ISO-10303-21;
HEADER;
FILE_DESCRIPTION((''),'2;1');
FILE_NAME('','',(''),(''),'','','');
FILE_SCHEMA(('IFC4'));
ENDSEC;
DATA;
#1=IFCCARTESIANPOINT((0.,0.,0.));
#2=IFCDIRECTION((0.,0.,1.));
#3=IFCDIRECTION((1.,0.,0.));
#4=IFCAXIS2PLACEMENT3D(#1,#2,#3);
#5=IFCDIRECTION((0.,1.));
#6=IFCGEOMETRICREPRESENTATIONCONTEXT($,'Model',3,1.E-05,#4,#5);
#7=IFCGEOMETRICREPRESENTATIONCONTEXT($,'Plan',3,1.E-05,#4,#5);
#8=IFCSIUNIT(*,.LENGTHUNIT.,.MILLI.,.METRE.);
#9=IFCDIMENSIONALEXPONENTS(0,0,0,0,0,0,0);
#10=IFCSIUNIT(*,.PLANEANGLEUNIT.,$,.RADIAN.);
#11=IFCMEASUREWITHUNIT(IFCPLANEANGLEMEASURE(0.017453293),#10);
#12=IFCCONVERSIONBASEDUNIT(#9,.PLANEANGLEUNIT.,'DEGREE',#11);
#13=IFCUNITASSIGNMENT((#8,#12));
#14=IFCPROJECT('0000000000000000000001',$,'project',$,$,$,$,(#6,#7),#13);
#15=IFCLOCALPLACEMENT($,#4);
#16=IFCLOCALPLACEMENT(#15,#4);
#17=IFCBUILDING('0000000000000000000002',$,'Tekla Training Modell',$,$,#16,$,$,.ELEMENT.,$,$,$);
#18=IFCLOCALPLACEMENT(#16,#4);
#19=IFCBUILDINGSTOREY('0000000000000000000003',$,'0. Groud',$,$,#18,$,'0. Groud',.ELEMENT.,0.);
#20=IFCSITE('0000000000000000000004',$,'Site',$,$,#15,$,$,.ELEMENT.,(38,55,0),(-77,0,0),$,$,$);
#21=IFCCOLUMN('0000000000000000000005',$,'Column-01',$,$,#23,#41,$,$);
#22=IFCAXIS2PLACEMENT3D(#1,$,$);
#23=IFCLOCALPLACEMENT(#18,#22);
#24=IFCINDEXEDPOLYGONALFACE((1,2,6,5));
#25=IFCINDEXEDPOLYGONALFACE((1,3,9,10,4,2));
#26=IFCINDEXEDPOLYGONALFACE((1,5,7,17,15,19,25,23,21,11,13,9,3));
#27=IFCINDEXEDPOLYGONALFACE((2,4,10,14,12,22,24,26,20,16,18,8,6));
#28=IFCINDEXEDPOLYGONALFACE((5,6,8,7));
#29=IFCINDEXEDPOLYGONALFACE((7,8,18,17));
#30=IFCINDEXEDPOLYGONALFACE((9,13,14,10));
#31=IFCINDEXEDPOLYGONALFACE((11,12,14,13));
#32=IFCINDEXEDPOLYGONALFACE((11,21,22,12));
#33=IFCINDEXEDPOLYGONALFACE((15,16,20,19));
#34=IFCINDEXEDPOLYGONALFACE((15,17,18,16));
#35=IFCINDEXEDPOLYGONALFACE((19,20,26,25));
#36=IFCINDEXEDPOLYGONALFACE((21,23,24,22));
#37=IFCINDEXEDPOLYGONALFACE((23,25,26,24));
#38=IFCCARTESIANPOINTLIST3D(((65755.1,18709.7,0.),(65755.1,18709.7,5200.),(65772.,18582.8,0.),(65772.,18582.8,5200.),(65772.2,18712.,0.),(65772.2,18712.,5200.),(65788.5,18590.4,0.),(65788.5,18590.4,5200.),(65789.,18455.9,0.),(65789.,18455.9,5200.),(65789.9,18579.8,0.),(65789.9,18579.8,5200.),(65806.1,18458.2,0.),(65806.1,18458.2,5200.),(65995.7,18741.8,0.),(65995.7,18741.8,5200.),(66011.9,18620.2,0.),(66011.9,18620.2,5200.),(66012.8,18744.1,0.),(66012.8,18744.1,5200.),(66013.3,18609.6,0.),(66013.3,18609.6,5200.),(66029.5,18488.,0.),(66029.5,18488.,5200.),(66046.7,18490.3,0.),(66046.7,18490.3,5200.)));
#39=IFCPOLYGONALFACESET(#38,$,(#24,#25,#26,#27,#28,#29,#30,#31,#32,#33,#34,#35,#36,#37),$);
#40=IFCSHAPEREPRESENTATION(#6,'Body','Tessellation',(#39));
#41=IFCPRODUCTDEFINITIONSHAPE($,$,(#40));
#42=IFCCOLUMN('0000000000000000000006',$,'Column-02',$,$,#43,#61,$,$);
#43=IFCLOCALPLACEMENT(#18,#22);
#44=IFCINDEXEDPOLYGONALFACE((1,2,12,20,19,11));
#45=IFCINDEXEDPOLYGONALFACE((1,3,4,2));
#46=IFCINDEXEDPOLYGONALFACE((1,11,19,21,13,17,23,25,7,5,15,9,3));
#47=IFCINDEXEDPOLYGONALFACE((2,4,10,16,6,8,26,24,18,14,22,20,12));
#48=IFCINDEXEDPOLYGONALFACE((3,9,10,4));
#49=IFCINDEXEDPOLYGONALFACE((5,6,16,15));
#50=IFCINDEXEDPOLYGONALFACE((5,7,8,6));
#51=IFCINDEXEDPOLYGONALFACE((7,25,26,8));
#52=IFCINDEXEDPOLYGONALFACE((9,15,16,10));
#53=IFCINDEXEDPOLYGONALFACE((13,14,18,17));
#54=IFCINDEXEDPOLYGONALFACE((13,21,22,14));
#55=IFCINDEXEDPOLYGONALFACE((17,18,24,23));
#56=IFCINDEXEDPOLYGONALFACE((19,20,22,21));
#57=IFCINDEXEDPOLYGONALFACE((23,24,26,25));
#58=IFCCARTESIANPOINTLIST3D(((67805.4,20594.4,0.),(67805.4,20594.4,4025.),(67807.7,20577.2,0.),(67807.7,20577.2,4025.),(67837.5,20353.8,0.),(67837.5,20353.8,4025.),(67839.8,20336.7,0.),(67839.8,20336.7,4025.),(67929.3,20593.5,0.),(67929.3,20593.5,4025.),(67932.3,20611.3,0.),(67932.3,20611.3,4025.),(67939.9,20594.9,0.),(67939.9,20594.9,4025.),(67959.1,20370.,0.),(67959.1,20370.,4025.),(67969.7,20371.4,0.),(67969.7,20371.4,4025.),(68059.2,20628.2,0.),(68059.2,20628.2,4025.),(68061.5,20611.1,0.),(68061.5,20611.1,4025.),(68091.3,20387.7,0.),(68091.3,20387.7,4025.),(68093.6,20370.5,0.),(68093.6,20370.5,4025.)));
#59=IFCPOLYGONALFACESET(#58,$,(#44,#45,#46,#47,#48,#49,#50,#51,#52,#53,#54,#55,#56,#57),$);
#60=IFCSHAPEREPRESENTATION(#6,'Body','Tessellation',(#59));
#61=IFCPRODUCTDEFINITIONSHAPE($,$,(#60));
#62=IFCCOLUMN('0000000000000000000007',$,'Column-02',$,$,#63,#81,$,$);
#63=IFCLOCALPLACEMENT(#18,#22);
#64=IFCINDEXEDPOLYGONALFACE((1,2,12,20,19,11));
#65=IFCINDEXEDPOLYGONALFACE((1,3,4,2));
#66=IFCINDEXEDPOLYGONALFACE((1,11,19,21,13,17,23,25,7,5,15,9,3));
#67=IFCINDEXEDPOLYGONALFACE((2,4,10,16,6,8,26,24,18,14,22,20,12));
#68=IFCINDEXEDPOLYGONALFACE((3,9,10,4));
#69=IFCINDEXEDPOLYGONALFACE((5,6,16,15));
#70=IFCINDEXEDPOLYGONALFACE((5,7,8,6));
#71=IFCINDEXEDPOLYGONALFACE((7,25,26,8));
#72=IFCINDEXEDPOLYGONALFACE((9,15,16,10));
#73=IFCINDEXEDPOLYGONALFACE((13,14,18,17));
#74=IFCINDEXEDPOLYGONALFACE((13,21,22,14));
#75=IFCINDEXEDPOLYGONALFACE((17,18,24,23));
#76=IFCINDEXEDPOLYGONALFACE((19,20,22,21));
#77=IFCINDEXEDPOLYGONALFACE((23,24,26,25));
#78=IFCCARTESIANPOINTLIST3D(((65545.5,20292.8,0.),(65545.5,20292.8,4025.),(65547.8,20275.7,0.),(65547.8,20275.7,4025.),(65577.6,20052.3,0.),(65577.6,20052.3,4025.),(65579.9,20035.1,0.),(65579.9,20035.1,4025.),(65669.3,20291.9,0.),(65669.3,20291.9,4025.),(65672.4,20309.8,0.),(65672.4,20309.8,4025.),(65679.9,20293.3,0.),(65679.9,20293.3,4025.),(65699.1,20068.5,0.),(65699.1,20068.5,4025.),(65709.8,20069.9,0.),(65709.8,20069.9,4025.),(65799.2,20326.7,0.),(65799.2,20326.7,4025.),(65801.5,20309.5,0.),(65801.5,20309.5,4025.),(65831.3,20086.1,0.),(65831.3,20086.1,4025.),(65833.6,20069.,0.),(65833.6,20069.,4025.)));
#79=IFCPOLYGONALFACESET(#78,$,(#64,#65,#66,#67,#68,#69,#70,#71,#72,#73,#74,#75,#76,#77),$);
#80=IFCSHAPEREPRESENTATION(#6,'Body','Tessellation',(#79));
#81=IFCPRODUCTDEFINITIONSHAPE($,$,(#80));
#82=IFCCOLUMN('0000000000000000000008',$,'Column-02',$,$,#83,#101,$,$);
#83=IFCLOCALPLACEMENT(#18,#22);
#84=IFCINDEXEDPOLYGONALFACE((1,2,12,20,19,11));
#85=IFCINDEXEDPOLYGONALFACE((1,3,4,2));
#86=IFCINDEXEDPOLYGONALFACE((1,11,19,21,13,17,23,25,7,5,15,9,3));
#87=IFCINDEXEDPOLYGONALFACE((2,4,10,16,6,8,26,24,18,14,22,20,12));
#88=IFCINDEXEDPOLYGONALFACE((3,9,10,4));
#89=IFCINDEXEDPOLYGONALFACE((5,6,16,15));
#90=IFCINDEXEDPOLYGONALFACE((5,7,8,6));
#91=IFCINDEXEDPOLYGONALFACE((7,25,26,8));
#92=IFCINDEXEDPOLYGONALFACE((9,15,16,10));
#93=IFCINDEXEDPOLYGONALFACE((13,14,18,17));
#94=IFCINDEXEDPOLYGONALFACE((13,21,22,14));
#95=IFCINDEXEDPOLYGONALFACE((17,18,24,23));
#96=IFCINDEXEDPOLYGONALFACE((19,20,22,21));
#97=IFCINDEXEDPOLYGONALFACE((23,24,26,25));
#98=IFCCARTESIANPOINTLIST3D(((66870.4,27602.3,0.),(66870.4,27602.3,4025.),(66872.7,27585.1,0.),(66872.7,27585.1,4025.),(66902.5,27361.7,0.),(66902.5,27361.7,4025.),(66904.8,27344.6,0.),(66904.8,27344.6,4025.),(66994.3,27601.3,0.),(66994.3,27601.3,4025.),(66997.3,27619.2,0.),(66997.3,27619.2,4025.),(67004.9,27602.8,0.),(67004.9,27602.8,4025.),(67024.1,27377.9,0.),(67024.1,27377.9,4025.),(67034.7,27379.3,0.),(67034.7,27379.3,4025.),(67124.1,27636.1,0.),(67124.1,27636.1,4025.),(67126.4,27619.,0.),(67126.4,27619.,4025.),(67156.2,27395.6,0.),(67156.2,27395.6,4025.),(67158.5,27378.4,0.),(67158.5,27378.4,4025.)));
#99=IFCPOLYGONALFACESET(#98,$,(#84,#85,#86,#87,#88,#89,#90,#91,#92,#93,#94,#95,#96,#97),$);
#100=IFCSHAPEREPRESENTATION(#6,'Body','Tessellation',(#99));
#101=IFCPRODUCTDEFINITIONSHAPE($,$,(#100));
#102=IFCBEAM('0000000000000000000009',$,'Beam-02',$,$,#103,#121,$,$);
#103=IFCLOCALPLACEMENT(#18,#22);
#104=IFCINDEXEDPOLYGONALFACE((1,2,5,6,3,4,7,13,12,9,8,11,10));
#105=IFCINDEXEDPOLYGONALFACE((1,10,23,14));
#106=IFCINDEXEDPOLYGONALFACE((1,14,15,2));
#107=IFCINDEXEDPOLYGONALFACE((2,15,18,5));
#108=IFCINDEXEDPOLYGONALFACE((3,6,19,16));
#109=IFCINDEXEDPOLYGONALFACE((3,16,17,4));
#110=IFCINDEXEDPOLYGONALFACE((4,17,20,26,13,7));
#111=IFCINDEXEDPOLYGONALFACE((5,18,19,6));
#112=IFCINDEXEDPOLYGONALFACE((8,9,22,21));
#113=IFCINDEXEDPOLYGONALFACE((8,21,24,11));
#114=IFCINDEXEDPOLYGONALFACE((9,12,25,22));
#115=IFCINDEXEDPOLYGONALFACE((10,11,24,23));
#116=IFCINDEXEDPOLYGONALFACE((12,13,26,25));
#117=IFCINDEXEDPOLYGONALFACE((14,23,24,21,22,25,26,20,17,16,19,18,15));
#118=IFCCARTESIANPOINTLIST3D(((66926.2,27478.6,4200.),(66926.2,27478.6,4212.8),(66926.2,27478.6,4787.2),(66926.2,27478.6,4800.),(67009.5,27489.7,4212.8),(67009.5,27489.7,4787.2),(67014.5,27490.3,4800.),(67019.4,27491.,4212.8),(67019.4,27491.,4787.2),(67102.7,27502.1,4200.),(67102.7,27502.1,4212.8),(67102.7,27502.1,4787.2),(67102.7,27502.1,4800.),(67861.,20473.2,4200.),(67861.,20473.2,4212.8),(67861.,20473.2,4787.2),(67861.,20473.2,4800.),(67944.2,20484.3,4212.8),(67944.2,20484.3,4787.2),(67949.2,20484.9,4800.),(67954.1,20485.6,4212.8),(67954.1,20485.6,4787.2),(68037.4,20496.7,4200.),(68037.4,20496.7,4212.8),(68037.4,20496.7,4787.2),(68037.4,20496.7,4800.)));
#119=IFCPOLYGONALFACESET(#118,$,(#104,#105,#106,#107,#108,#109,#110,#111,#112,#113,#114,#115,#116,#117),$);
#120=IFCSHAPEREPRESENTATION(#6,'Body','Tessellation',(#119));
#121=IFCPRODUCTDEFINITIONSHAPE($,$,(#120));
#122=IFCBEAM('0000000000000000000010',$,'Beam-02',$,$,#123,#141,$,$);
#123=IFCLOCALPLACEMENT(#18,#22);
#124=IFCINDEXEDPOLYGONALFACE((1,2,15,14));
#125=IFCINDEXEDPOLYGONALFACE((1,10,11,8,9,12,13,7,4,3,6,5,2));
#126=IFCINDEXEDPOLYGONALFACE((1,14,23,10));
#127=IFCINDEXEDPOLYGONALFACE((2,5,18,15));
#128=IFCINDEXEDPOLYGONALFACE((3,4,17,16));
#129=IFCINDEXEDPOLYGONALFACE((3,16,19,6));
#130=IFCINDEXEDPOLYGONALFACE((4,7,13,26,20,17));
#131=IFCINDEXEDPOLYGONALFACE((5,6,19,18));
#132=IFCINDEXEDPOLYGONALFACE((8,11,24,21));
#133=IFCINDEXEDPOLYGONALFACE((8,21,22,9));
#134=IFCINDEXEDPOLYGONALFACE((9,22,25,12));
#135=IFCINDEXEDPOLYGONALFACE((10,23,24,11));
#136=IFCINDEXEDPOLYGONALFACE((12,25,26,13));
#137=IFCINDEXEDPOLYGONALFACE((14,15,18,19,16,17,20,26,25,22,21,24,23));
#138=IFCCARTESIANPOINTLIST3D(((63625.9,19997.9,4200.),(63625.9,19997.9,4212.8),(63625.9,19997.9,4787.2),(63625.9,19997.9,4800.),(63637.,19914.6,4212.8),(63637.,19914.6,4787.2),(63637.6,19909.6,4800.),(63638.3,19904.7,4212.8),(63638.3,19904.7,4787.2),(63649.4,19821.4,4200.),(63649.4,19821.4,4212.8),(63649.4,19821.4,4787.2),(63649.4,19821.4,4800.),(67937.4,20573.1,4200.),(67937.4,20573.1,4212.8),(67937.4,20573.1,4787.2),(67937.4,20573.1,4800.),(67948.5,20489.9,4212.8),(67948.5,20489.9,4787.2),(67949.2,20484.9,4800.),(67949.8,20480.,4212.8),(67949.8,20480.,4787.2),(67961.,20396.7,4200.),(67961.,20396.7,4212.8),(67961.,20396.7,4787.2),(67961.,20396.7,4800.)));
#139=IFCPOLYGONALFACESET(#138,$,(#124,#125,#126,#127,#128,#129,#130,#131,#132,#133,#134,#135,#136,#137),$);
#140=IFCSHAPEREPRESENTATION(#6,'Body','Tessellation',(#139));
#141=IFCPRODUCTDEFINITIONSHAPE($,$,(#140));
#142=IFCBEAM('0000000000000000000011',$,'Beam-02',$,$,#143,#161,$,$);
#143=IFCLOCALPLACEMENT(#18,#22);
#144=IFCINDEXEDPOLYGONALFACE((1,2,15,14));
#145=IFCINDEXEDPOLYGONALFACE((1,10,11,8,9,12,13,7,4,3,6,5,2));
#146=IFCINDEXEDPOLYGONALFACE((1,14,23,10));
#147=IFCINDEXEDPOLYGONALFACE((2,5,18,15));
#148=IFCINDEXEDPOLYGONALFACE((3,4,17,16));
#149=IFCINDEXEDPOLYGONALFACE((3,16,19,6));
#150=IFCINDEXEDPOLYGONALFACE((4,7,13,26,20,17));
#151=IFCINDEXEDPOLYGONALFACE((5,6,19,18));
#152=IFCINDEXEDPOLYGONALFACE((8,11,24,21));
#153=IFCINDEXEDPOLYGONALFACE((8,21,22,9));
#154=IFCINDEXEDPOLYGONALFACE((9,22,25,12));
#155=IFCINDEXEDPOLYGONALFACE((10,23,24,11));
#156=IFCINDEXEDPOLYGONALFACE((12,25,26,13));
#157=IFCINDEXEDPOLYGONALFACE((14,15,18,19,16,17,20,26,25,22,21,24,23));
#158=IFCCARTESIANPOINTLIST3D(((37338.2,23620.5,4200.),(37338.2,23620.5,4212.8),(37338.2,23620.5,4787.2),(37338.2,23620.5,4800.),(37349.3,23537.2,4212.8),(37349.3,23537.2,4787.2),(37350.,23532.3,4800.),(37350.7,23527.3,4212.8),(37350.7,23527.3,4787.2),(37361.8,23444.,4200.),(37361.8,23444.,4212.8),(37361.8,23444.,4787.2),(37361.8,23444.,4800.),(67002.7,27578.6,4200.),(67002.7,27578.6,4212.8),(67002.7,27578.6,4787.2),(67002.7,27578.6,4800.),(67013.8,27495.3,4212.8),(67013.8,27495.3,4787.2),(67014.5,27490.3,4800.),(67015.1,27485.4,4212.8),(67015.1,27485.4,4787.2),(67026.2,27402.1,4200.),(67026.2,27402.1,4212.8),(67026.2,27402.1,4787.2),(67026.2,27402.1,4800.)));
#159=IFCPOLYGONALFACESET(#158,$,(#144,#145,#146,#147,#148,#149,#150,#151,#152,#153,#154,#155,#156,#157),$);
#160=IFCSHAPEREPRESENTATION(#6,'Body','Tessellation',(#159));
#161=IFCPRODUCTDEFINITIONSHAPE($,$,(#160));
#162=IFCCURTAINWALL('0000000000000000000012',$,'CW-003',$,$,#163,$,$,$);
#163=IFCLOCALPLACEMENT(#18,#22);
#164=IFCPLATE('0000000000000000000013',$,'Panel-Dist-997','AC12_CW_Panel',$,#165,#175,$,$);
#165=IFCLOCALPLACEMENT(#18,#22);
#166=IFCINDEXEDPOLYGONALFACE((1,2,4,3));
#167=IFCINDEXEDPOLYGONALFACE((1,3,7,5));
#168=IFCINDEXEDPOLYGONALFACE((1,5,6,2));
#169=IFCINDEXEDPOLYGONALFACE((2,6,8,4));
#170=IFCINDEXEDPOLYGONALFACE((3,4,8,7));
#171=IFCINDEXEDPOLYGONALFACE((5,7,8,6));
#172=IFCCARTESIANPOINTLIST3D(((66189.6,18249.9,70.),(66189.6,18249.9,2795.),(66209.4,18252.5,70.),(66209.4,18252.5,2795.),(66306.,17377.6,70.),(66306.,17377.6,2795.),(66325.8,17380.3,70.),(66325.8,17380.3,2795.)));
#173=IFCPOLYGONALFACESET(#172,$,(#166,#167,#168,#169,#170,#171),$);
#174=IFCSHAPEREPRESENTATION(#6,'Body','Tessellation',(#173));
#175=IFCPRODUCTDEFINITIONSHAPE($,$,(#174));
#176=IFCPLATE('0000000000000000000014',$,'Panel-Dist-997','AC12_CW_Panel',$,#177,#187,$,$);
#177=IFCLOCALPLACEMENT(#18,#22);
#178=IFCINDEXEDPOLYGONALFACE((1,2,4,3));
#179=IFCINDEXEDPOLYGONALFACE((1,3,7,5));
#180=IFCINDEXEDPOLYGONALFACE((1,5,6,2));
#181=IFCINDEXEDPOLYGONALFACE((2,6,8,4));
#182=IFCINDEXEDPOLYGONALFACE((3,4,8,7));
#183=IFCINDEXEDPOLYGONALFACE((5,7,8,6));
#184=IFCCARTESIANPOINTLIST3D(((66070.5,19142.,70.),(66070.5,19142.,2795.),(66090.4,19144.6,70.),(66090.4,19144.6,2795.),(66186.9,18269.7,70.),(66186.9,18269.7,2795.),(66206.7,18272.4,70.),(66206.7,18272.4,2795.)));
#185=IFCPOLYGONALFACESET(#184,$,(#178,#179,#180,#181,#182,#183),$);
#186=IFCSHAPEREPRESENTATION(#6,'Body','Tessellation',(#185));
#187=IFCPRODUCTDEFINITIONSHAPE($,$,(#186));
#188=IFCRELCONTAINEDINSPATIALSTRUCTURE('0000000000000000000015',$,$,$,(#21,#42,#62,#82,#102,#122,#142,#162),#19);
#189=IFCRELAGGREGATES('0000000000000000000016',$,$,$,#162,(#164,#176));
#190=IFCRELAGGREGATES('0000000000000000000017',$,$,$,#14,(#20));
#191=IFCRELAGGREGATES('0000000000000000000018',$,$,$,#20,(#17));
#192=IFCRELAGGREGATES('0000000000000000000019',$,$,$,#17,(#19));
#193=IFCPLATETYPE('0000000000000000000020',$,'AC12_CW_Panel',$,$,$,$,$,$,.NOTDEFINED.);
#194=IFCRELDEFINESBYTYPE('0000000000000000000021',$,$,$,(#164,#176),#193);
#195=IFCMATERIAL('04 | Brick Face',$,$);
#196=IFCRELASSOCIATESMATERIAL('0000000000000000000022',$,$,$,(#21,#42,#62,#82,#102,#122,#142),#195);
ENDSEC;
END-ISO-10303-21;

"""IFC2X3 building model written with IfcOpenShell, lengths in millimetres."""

from ifc_helpers import new_model, entity, si_unit, converted_unit, direction, frame, origin_with_axes, place, context, project, spatial, polyline, outline, extrude, source, transform, mapped, material, type_object, element, aggregate, save


model = new_model("IFC2X3")

# Units and contexts
model_context = context("Model", 3, precision=1e-05, world=origin_with_axes(), true_north=direction((0.0, 1.0)))
plan_context = context("Plan", 3, precision=1e-05, world=origin_with_axes(), true_north=direction((0.0, 1.0)))
ifc_project = project(units=[si_unit("LENGTHUNIT", "METRE", prefix="MILLI"), converted_unit("PLANEANGLEUNIT", "DEGREE", entity("IfcPlaneAngleMeasure", 0.017453293), si_unit("PLANEANGLEUNIT", "RADIAN"), dimensions=[0, 0, 0, 0, 0, 0, 0])], contexts=[model_context, plan_context])

# Site, building, storey
site_placement = place(None, origin_with_axes())
site = spatial("IfcSite", under=ifc_project, at=site_placement, Name="Site", CompositionType="ELEMENT", RefLatitude=(38, 55, 0), RefLongitude=(-77, 0, 0))
building_placement = place(site_placement, origin_with_axes())
building = spatial("IfcBuilding", under=site, at=building_placement, Name="Tekla Training Modell", CompositionType="ELEMENT")
storey_placement = place(building_placement, origin_with_axes())
storey = spatial("IfcBuildingStorey", under=building, at=storey_placement, Name="0. Groud", LongName="0. Groud", CompositionType="ELEMENT", Elevation=0.0)

# Columns
ifc_material_1 = material(Name="04 | Brick Face")
column_placement = place(storey_placement, frame((65900.9, 18600.0, 0.0), z_axis=(0.0, 0.0, 1.0), x_axis=(-0.132256, 0.991216, 0.0)))
element("IfcColumn", 1, at=column_placement, inside=storey, material=ifc_material_1, Name="Column-01", context=model_context, shape_type="SweptSolid", body=[
    extrude(outline(polyline([(0.0, 130.0), (-128.0, 130.0), (-128.0, 112.7), (-5.3, 112.7), (-5.3, -112.7), (-128.0, -112.7), (-128.0, -130.0), (128.0, -130.0), (128.0, -112.7), (5.3, -112.7), (5.3, 112.7), (128.0, 112.7), (128.0, 130.0), (0.0, 130.0)])), origin_with_axes(), (0.0, 0.0, 1.0), 5200.0),
])
for number, where, z_axis, x_axis, name in (
    (2, (67949.5, 20482.5, 0.0), (0.0, 0.0, 1.0), (0.991216, 0.132256, 0.0), "Column-02"),
    (3, (65689.5, 20180.9, 0.0), (0.0, 0.0, 1.0), (0.991216, 0.132256, 0.0), "Column-02"),
    (4, (67014.5, 27490.3, 0.0), (0.0, 0.0, 1.0), (0.991216, 0.132256, 0.0), "Column-02"),
):
    element("IfcColumn", number, at=place(storey_placement, frame(where, z_axis=z_axis, x_axis=x_axis)), inside=storey, material=ifc_material_1, Name=name, context=model_context, shape_type="SweptSolid", body=[
        extrude(outline(polyline([(0.0, 130.0), (-128.0, 130.0), (-128.0, 112.7), (-5.3, 112.7), (-5.3, -112.7), (-128.0, -112.7), (-128.0, -130.0), (128.0, -130.0), (128.0, -112.7), (5.3, -112.7), (5.3, 112.7), (128.0, 112.7), (128.0, 130.0), (0.0, 130.0)])), origin_with_axes(), (0.0, 0.0, 1.0), 4025.0),
    ])

# Beams
beam_1_placement = place(storey_placement, frame((67949.2, 20484.9, 4500.0), z_axis=(0.0, 0.0, 1.0), x_axis=(0.991216, 0.132256, 0.0)))
element("IfcBeam", 5, at=beam_1_placement, inside=storey, material=ifc_material_1, Name="Beam-02", context=model_context, shape_type="SweptSolid", body=[
    extrude(outline(polyline([(0.0, 300.0), (-89.0, 300.0), (-89.0, 287.2), (-5.0, 287.2), (-5.0, -287.2), (-89.0, -287.2), (-89.0, -300.0), (89.0, -300.0), (89.0, -287.2), (5.0, -287.2), (5.0, 287.2), (89.0, 287.2), (89.0, 300.0), (0.0, 300.0)])), frame((0.0, 7067.5, 0.0), z_axis=(0.0, -1.0, 0.0), x_axis=(1.0, 0.0, 0.0)), (0.0, 0.0, 1.0), 7067.5),
])
beam_2_placement = place(storey_placement, frame((67949.2, 20484.9, 4500.0), z_axis=(0.0, 0.0, 1.0), x_axis=(-0.132257, 0.991216, 0.0)))
element("IfcBeam", 6, at=beam_2_placement, inside=storey, material=ifc_material_1, Name="Beam-02", context=model_context, shape_type="SweptSolid", body=[
    extrude(outline(polyline([(0.0, 300.0), (-89.0, 300.0), (-89.0, 287.2), (-5.0, 287.2), (-5.0, -287.2), (-89.0, -287.2), (-89.0, -300.0), (89.0, -300.0), (89.0, -287.2), (5.0, -287.2), (5.0, 287.2), (89.0, 287.2), (89.0, 300.0), (0.0, 300.0)])), frame((0.0, 4349.8, 0.0), z_axis=(0.0, -1.0, 0.0), x_axis=(1.0, 0.0, 0.0)), (0.0, 0.0, 1.0), 4349.8),
])
beam_3_placement = place(storey_placement, frame((67014.5, 27490.3, 4500.0), z_axis=(0.0, 0.0, 1.0), x_axis=(-0.132256, 0.991216, 0.0)))
element("IfcBeam", 7, at=beam_3_placement, inside=storey, material=ifc_material_1, Name="Beam-02", context=model_context, shape_type="SweptSolid", body=[
    extrude(outline(polyline([(0.0, 300.0), (-89.0, 300.0), (-89.0, 287.2), (-5.0, 287.2), (-5.0, -287.2), (-89.0, -287.2), (-89.0, -300.0), (89.0, -300.0), (89.0, -287.2), (5.0, -287.2), (5.0, 287.2), (89.0, 287.2), (89.0, 300.0), (0.0, 300.0)])), frame((0.0, 29927.4, 0.0), z_axis=(0.0, -1.0, 0.0), x_axis=(1.0, 0.0, 0.0)), (0.0, 0.0, 1.0), 29927.4),
])

# Curtain wall, plates
curtain_wall_placement = place(storey_placement, frame((68221.7, 3095.5, 0.0), z_axis=(0.0, 0.0, 1.0), x_axis=(-0.132257, 0.991216, 0.0)))
curtain_wall = element("IfcCurtainWall", 8, at=curtain_wall_placement, inside=storey, Name="CW-003")
plate_type = type_object("IfcPlateType", Name="AC12_CW_Panel", PredefinedType="NOTDEFINED")
shared_shape_1 = source(origin_with_axes(), model_context, "Body", "SweptSolid", [
    extrude(outline(polyline([(0.0, 0.0), (880.0, 0.0), (880.0, -20.0), (0.0, -20.0), (0.0, 0.0)])), origin_with_axes(), (0.0, 0.0, 1.0), 2725.0),
])
plate_1_placement = place(storey_placement, frame((66306.0, 17377.6, 70.0), z_axis=(0.0, 0.0, 1.0), x_axis=(-0.132257, 0.991216, 0.0)))
plate_1 = element("IfcPlate", 9, at=plate_1_placement, type_object=plate_type, Name="Panel-Dist-997", Description="AC12_CW_Panel", context=model_context, shape_type="MappedRepresentation", body=[
    mapped(shared_shape_1, transform((0.0, 0.0, 0.0), scale=1.0)),
])
plate_2_placement = place(storey_placement, frame((66186.9, 18269.7, 70.0), z_axis=(0.0, 0.0, 1.0), x_axis=(-0.132257, 0.991216, 0.0)))
plate_2 = element("IfcPlate", 10, at=plate_2_placement, type_object=plate_type, Name="Panel-Dist-997", Description="AC12_CW_Panel", context=model_context, shape_type="MappedRepresentation", body=[
    mapped(shared_shape_1, transform((0.0, 0.0, 0.0), scale=1.0)),
])

aggregate(curtain_wall, [plate_1, plate_2])

save(model, "model.ifc")
